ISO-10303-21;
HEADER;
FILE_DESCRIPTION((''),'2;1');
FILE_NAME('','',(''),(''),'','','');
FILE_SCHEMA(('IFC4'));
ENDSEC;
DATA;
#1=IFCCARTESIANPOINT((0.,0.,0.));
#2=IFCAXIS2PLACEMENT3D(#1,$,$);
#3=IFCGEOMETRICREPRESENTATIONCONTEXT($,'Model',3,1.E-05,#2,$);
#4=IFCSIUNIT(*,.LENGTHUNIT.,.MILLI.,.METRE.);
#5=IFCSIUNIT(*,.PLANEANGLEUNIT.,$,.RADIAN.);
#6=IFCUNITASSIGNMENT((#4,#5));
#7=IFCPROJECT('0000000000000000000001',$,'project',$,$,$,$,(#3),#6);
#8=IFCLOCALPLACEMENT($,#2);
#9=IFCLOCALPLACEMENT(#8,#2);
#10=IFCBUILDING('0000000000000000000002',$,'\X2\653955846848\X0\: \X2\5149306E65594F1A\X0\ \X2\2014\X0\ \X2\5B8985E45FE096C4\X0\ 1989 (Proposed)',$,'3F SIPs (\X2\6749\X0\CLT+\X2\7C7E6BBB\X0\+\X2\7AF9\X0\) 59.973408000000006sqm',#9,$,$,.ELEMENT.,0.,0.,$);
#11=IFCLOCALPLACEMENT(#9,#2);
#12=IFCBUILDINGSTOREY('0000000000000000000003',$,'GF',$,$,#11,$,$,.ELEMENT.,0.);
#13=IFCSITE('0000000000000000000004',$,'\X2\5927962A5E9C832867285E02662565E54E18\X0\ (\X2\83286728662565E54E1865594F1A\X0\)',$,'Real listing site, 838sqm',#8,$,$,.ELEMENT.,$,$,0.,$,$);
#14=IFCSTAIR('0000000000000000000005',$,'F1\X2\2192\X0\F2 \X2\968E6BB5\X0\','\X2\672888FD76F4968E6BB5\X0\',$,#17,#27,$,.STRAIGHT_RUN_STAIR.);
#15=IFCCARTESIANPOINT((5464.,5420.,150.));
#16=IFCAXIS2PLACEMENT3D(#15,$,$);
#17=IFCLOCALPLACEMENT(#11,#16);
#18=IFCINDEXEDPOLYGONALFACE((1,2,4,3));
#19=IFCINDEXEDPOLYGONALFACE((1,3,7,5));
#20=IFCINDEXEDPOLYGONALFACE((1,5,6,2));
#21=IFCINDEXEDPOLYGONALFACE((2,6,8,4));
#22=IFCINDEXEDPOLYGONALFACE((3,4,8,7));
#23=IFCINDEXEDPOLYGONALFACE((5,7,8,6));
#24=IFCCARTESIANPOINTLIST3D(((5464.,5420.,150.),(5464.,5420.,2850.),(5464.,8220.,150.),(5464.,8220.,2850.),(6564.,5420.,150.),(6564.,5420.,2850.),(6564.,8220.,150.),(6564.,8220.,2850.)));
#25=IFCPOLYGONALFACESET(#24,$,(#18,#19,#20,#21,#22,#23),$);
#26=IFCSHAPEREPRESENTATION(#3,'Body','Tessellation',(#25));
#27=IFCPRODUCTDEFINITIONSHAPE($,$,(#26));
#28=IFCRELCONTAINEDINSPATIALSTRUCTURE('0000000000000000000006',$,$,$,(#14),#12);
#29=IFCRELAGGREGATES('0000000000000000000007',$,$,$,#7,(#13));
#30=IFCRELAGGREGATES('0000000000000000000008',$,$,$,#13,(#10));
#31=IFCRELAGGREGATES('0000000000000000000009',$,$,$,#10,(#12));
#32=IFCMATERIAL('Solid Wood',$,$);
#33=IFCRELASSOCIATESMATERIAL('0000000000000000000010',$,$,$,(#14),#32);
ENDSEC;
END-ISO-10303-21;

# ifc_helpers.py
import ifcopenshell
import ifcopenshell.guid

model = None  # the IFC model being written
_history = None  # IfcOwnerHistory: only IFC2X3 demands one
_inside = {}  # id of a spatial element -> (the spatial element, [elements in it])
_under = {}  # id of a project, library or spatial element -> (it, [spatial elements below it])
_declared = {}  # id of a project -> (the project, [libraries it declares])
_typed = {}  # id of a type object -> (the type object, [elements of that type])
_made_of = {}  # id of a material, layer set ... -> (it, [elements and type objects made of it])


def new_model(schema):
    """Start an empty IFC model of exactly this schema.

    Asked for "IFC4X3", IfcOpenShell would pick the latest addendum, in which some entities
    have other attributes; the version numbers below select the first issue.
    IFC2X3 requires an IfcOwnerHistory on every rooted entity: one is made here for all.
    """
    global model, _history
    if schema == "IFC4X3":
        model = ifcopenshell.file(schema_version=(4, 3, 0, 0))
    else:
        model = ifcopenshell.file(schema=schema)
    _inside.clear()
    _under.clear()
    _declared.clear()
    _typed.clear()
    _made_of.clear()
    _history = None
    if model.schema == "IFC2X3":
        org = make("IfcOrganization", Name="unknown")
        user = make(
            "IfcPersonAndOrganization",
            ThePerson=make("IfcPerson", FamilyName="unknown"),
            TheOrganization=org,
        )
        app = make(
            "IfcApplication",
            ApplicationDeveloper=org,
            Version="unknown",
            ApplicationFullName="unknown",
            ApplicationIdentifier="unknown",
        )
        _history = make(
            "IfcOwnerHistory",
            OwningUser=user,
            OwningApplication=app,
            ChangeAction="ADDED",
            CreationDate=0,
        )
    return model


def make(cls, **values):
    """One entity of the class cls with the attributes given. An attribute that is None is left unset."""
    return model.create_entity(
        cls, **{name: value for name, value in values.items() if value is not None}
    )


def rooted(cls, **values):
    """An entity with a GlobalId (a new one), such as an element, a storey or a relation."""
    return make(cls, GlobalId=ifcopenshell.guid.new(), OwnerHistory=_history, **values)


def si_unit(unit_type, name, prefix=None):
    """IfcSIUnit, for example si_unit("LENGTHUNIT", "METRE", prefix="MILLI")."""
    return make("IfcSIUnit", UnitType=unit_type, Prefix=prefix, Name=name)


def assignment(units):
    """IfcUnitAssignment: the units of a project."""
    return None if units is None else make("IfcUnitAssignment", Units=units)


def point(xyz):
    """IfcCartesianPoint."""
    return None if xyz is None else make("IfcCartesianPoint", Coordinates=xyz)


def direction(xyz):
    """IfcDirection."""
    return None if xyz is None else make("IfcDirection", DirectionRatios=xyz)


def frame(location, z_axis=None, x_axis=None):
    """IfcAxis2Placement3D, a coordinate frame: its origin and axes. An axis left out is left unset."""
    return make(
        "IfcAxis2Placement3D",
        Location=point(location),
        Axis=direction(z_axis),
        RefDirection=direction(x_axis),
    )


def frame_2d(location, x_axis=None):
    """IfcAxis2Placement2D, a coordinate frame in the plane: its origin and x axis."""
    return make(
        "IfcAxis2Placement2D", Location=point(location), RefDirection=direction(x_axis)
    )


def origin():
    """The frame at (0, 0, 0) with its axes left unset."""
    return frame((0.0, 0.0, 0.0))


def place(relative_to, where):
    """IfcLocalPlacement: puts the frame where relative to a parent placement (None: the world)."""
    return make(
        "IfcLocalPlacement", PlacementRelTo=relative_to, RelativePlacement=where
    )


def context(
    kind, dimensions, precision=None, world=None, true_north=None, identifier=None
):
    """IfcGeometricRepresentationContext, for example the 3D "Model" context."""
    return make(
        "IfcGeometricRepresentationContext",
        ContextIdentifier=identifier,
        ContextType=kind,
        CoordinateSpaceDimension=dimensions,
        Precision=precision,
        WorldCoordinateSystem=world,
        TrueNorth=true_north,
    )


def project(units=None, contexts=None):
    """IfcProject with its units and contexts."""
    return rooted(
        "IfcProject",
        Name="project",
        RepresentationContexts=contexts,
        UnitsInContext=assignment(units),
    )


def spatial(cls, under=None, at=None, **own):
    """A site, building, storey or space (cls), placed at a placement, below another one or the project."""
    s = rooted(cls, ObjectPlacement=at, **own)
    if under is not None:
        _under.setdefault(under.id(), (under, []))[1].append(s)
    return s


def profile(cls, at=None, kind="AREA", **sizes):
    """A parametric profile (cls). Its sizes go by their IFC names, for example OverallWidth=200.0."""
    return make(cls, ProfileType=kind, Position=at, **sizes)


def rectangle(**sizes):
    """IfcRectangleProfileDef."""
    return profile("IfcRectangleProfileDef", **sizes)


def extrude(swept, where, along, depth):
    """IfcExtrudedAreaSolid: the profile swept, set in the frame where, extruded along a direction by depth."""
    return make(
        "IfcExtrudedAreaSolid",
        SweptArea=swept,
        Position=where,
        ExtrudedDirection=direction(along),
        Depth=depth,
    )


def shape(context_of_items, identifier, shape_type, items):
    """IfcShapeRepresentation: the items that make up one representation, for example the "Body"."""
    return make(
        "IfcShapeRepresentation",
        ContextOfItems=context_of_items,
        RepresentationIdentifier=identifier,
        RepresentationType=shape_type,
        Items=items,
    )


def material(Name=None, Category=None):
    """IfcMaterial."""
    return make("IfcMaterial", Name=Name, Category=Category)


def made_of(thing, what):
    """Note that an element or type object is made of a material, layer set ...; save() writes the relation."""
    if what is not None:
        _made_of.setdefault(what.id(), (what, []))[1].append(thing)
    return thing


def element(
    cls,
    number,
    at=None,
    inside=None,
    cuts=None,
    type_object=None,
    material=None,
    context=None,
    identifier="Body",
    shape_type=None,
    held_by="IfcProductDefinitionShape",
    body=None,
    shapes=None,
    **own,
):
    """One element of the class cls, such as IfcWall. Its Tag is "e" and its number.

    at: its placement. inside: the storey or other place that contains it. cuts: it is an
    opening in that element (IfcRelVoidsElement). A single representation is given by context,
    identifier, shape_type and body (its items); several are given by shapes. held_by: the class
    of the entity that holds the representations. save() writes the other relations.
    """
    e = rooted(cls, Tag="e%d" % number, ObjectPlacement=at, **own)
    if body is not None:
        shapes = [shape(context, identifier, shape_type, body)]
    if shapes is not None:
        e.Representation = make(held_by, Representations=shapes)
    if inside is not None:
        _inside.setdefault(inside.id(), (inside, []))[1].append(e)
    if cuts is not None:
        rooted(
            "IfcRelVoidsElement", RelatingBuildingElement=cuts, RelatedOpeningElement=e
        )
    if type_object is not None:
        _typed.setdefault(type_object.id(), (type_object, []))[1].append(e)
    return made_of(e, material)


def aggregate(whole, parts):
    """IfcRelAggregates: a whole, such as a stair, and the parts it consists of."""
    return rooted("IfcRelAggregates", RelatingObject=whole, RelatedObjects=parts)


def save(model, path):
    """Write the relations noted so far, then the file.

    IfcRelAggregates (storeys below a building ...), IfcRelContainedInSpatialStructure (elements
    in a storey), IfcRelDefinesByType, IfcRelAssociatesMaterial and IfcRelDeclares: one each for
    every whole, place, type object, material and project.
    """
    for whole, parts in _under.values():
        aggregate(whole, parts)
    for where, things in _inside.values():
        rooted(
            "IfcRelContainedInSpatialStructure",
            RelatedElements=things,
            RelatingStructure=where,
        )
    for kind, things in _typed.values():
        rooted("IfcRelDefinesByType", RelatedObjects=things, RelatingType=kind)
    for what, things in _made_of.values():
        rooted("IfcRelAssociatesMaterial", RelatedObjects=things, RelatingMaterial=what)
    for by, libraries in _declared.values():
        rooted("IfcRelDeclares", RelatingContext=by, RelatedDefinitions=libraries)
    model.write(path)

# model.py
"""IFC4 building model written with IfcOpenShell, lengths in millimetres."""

from ifc_helpers import new_model, si_unit, frame, frame_2d, origin, place, context, project, spatial, rectangle, extrude, material, element, save


model = new_model("IFC4")

# Units and contexts
model_context = context("Model", 3, precision=1e-05, world=origin())
ifc_project = project(units=[si_unit("LENGTHUNIT", "METRE", prefix="MILLI"), si_unit("PLANEANGLEUNIT", "RADIAN")], contexts=[model_context])

# Site, building, storey
site_placement = place(None, origin())
site = spatial("IfcSite", under=ifc_project, at=site_placement, Name="大阪府茨木市春日丘 (茨木春日丘教会)", ObjectType="Real listing site, 838sqm", CompositionType="ELEMENT", RefElevation=0.0)
building_placement = place(site_placement, origin())
building = spatial("IfcBuilding", under=site, at=building_placement, Name="改善案: 光の教会 — 安藤忠雄 1989 (Proposed)", ObjectType="3F SIPs (杉CLT+籾殻+竹) 59.973408000000006sqm", CompositionType="ELEMENT", ElevationOfRefHeight=0.0, ElevationOfTerrain=0.0)
storey_placement = place(building_placement, origin())
storey = spatial("IfcBuildingStorey", under=building, at=storey_placement, Name="GF", CompositionType="ELEMENT", Elevation=0.0)

# Shared definitions
ifc_material_1 = material(Name="Solid Wood")

# Stair
stair_placement = place(storey_placement, frame((5464.0, 5420.0, 150.0)))
element("IfcStair", 1, at=stair_placement, inside=storey, material=ifc_material_1, Name="F1→F2 階段", Description="木製直階段", PredefinedType="STRAIGHT_RUN_STAIR", context=model_context, shape_type="SweptSolid", body=[
    extrude(rectangle(XDim=1100.0, YDim=2800.0, at=frame_2d((550.0, 1400.0))), frame((5464.0, 5420.0, 150.0)), (0.0, 0.0, 1.0), 2700.0),
])

save(model, "model.ifc")
